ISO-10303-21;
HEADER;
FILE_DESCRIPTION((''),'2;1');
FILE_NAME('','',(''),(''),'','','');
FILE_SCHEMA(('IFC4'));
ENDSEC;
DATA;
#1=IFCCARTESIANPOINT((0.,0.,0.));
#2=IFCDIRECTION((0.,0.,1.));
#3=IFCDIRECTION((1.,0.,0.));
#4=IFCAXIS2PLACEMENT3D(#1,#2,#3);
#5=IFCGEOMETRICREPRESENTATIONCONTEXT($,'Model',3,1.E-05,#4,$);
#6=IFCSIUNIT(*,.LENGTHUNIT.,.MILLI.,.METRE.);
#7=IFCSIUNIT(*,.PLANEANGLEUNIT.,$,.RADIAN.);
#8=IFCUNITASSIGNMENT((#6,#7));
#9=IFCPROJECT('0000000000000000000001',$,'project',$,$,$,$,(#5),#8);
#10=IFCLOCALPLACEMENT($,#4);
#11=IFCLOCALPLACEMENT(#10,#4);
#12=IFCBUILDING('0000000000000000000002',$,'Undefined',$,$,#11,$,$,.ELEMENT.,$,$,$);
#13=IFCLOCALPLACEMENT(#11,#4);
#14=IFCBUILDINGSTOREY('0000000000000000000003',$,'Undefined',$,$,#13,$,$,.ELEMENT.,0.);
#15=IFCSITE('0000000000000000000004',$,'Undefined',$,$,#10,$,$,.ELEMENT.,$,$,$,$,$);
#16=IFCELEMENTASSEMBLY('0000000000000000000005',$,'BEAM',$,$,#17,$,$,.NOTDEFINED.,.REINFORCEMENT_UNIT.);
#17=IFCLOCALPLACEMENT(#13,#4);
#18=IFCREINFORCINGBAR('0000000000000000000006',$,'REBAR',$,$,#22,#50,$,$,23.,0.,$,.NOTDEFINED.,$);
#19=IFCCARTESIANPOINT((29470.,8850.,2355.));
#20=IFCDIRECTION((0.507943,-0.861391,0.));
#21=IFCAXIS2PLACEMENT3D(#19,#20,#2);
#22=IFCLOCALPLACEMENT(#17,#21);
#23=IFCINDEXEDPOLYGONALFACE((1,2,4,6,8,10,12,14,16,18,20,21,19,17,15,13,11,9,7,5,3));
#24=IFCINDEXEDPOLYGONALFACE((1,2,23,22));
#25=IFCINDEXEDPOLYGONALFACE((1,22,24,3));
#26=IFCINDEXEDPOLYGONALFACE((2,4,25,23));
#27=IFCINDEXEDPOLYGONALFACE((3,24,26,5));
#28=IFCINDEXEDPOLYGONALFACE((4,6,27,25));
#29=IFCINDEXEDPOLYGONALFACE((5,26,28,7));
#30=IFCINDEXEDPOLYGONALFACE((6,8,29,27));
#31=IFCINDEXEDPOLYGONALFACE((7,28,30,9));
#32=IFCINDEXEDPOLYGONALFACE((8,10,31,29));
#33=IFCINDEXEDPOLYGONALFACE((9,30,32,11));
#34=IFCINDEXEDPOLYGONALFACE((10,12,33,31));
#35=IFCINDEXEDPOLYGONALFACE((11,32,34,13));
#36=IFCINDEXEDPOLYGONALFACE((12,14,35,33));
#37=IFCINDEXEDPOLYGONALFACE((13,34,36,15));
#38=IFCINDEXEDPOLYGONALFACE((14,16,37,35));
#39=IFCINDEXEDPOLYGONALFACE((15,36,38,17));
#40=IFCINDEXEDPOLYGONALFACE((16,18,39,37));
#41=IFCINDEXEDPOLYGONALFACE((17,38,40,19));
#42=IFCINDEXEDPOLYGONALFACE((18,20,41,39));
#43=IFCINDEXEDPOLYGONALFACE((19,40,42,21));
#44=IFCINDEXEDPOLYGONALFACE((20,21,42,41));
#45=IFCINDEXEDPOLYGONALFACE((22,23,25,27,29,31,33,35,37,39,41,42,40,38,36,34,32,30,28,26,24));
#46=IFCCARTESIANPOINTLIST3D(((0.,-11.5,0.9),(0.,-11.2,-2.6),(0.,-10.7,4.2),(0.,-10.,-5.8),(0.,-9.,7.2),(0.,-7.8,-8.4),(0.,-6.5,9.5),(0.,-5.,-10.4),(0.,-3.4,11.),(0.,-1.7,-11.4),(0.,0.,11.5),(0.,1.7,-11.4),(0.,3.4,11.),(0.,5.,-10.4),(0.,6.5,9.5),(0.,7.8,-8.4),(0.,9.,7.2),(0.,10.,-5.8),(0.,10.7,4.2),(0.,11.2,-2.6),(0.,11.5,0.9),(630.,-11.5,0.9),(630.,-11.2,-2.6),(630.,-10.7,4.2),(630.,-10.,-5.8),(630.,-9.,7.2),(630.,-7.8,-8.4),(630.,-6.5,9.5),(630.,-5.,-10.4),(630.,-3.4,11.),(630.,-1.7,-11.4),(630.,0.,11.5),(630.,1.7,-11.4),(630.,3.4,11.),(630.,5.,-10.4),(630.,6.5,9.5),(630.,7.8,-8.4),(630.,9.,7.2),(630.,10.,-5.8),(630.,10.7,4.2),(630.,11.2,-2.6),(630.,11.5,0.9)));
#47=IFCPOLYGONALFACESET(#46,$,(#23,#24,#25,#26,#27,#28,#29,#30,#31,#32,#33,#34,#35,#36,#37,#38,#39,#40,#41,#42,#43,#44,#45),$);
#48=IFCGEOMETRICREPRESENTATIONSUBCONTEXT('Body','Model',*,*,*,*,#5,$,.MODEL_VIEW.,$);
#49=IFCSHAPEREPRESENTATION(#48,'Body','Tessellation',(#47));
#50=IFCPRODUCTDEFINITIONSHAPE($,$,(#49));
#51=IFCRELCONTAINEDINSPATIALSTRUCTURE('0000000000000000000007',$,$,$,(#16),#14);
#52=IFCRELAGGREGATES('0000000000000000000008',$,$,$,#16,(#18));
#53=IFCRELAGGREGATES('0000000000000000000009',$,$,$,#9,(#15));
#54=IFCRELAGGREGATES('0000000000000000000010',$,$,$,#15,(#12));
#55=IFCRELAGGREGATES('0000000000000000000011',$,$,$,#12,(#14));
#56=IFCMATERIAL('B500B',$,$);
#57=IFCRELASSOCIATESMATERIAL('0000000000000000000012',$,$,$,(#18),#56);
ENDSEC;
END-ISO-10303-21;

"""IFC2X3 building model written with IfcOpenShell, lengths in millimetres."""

from ifc_helpers import new_model, entity, si_unit, frame, origin_with_axes, place, context, subcontext, project, spatial, source, transform, mapped, material, element, aggregate, save


model = new_model("IFC2X3")

# Units and contexts
model_context = context("Model", 3, precision=1e-05, world=origin_with_axes())
body_context = subcontext(model_context, "Body", "Model", "MODEL_VIEW")
ifc_project = project(units=[si_unit("LENGTHUNIT", "METRE", prefix="MILLI"), si_unit("PLANEANGLEUNIT", "RADIAN")], contexts=[model_context])

# Site, building, storey
site_placement = place(None, origin_with_axes())
site = spatial("IfcSite", under=ifc_project, at=site_placement, Name="Undefined", CompositionType="ELEMENT")
building_placement = place(site_placement, origin_with_axes())
building = spatial("IfcBuilding", under=site, at=building_placement, Name="Undefined", CompositionType="ELEMENT")
storey_placement = place(building_placement, origin_with_axes())
storey = spatial("IfcBuildingStorey", under=building, at=storey_placement, Name="Undefined", CompositionType="ELEMENT", Elevation=0.0)

# Element assembly
assembly_1_placement = place(storey_placement, origin_with_axes())
assembly_1 = element("IfcElementAssembly", 1, at=assembly_1_placement, inside=storey, Name="BEAM", AssemblyPlace="NOTDEFINED", PredefinedType="REINFORCEMENT_UNIT")

# Reinforcing bar
ifc_material_1 = material(Name="B500B")
shared_shape_1 = source(origin_with_axes(), body_context, "Body", "AdvancedSweptSolid", [
    entity("IfcSweptDiskSolid", entity("IfcTrimmedCurve", entity("IfcLine", entity("IfcCartesianPoint", [0.0, 0.0, 0.0]), entity("IfcVector", entity("IfcDirection", [1.0, 0.0, 0.0]), 1.0)), [entity("IfcParameterValue", 0.0)], [entity("IfcParameterValue", 630.0)], True, "PARAMETER"), 11.5, None, 0.0, 630.0),
])
reinforcing_bar_1_placement = place(assembly_1_placement, frame((29470.0, 8850.0, 2355.0), z_axis=(0.507943, -0.861391, 0.0), x_axis=(0.0, 0.0, 1.0)))
reinforcing_bar_1 = element("IfcReinforcingBar", 2, at=reinforcing_bar_1_placement, material=ifc_material_1, Name="REBAR", BarRole="NOTDEFINED", CrossSectionArea=0.0, NominalDiameter=23.0, context=body_context, shape_type="MappedRepresentation", body=[
    mapped(shared_shape_1, transform((0.0, 0.0, 0.0))),
])
aggregate(assembly_1, [reinforcing_bar_1])

save(model, "model.ifc")
